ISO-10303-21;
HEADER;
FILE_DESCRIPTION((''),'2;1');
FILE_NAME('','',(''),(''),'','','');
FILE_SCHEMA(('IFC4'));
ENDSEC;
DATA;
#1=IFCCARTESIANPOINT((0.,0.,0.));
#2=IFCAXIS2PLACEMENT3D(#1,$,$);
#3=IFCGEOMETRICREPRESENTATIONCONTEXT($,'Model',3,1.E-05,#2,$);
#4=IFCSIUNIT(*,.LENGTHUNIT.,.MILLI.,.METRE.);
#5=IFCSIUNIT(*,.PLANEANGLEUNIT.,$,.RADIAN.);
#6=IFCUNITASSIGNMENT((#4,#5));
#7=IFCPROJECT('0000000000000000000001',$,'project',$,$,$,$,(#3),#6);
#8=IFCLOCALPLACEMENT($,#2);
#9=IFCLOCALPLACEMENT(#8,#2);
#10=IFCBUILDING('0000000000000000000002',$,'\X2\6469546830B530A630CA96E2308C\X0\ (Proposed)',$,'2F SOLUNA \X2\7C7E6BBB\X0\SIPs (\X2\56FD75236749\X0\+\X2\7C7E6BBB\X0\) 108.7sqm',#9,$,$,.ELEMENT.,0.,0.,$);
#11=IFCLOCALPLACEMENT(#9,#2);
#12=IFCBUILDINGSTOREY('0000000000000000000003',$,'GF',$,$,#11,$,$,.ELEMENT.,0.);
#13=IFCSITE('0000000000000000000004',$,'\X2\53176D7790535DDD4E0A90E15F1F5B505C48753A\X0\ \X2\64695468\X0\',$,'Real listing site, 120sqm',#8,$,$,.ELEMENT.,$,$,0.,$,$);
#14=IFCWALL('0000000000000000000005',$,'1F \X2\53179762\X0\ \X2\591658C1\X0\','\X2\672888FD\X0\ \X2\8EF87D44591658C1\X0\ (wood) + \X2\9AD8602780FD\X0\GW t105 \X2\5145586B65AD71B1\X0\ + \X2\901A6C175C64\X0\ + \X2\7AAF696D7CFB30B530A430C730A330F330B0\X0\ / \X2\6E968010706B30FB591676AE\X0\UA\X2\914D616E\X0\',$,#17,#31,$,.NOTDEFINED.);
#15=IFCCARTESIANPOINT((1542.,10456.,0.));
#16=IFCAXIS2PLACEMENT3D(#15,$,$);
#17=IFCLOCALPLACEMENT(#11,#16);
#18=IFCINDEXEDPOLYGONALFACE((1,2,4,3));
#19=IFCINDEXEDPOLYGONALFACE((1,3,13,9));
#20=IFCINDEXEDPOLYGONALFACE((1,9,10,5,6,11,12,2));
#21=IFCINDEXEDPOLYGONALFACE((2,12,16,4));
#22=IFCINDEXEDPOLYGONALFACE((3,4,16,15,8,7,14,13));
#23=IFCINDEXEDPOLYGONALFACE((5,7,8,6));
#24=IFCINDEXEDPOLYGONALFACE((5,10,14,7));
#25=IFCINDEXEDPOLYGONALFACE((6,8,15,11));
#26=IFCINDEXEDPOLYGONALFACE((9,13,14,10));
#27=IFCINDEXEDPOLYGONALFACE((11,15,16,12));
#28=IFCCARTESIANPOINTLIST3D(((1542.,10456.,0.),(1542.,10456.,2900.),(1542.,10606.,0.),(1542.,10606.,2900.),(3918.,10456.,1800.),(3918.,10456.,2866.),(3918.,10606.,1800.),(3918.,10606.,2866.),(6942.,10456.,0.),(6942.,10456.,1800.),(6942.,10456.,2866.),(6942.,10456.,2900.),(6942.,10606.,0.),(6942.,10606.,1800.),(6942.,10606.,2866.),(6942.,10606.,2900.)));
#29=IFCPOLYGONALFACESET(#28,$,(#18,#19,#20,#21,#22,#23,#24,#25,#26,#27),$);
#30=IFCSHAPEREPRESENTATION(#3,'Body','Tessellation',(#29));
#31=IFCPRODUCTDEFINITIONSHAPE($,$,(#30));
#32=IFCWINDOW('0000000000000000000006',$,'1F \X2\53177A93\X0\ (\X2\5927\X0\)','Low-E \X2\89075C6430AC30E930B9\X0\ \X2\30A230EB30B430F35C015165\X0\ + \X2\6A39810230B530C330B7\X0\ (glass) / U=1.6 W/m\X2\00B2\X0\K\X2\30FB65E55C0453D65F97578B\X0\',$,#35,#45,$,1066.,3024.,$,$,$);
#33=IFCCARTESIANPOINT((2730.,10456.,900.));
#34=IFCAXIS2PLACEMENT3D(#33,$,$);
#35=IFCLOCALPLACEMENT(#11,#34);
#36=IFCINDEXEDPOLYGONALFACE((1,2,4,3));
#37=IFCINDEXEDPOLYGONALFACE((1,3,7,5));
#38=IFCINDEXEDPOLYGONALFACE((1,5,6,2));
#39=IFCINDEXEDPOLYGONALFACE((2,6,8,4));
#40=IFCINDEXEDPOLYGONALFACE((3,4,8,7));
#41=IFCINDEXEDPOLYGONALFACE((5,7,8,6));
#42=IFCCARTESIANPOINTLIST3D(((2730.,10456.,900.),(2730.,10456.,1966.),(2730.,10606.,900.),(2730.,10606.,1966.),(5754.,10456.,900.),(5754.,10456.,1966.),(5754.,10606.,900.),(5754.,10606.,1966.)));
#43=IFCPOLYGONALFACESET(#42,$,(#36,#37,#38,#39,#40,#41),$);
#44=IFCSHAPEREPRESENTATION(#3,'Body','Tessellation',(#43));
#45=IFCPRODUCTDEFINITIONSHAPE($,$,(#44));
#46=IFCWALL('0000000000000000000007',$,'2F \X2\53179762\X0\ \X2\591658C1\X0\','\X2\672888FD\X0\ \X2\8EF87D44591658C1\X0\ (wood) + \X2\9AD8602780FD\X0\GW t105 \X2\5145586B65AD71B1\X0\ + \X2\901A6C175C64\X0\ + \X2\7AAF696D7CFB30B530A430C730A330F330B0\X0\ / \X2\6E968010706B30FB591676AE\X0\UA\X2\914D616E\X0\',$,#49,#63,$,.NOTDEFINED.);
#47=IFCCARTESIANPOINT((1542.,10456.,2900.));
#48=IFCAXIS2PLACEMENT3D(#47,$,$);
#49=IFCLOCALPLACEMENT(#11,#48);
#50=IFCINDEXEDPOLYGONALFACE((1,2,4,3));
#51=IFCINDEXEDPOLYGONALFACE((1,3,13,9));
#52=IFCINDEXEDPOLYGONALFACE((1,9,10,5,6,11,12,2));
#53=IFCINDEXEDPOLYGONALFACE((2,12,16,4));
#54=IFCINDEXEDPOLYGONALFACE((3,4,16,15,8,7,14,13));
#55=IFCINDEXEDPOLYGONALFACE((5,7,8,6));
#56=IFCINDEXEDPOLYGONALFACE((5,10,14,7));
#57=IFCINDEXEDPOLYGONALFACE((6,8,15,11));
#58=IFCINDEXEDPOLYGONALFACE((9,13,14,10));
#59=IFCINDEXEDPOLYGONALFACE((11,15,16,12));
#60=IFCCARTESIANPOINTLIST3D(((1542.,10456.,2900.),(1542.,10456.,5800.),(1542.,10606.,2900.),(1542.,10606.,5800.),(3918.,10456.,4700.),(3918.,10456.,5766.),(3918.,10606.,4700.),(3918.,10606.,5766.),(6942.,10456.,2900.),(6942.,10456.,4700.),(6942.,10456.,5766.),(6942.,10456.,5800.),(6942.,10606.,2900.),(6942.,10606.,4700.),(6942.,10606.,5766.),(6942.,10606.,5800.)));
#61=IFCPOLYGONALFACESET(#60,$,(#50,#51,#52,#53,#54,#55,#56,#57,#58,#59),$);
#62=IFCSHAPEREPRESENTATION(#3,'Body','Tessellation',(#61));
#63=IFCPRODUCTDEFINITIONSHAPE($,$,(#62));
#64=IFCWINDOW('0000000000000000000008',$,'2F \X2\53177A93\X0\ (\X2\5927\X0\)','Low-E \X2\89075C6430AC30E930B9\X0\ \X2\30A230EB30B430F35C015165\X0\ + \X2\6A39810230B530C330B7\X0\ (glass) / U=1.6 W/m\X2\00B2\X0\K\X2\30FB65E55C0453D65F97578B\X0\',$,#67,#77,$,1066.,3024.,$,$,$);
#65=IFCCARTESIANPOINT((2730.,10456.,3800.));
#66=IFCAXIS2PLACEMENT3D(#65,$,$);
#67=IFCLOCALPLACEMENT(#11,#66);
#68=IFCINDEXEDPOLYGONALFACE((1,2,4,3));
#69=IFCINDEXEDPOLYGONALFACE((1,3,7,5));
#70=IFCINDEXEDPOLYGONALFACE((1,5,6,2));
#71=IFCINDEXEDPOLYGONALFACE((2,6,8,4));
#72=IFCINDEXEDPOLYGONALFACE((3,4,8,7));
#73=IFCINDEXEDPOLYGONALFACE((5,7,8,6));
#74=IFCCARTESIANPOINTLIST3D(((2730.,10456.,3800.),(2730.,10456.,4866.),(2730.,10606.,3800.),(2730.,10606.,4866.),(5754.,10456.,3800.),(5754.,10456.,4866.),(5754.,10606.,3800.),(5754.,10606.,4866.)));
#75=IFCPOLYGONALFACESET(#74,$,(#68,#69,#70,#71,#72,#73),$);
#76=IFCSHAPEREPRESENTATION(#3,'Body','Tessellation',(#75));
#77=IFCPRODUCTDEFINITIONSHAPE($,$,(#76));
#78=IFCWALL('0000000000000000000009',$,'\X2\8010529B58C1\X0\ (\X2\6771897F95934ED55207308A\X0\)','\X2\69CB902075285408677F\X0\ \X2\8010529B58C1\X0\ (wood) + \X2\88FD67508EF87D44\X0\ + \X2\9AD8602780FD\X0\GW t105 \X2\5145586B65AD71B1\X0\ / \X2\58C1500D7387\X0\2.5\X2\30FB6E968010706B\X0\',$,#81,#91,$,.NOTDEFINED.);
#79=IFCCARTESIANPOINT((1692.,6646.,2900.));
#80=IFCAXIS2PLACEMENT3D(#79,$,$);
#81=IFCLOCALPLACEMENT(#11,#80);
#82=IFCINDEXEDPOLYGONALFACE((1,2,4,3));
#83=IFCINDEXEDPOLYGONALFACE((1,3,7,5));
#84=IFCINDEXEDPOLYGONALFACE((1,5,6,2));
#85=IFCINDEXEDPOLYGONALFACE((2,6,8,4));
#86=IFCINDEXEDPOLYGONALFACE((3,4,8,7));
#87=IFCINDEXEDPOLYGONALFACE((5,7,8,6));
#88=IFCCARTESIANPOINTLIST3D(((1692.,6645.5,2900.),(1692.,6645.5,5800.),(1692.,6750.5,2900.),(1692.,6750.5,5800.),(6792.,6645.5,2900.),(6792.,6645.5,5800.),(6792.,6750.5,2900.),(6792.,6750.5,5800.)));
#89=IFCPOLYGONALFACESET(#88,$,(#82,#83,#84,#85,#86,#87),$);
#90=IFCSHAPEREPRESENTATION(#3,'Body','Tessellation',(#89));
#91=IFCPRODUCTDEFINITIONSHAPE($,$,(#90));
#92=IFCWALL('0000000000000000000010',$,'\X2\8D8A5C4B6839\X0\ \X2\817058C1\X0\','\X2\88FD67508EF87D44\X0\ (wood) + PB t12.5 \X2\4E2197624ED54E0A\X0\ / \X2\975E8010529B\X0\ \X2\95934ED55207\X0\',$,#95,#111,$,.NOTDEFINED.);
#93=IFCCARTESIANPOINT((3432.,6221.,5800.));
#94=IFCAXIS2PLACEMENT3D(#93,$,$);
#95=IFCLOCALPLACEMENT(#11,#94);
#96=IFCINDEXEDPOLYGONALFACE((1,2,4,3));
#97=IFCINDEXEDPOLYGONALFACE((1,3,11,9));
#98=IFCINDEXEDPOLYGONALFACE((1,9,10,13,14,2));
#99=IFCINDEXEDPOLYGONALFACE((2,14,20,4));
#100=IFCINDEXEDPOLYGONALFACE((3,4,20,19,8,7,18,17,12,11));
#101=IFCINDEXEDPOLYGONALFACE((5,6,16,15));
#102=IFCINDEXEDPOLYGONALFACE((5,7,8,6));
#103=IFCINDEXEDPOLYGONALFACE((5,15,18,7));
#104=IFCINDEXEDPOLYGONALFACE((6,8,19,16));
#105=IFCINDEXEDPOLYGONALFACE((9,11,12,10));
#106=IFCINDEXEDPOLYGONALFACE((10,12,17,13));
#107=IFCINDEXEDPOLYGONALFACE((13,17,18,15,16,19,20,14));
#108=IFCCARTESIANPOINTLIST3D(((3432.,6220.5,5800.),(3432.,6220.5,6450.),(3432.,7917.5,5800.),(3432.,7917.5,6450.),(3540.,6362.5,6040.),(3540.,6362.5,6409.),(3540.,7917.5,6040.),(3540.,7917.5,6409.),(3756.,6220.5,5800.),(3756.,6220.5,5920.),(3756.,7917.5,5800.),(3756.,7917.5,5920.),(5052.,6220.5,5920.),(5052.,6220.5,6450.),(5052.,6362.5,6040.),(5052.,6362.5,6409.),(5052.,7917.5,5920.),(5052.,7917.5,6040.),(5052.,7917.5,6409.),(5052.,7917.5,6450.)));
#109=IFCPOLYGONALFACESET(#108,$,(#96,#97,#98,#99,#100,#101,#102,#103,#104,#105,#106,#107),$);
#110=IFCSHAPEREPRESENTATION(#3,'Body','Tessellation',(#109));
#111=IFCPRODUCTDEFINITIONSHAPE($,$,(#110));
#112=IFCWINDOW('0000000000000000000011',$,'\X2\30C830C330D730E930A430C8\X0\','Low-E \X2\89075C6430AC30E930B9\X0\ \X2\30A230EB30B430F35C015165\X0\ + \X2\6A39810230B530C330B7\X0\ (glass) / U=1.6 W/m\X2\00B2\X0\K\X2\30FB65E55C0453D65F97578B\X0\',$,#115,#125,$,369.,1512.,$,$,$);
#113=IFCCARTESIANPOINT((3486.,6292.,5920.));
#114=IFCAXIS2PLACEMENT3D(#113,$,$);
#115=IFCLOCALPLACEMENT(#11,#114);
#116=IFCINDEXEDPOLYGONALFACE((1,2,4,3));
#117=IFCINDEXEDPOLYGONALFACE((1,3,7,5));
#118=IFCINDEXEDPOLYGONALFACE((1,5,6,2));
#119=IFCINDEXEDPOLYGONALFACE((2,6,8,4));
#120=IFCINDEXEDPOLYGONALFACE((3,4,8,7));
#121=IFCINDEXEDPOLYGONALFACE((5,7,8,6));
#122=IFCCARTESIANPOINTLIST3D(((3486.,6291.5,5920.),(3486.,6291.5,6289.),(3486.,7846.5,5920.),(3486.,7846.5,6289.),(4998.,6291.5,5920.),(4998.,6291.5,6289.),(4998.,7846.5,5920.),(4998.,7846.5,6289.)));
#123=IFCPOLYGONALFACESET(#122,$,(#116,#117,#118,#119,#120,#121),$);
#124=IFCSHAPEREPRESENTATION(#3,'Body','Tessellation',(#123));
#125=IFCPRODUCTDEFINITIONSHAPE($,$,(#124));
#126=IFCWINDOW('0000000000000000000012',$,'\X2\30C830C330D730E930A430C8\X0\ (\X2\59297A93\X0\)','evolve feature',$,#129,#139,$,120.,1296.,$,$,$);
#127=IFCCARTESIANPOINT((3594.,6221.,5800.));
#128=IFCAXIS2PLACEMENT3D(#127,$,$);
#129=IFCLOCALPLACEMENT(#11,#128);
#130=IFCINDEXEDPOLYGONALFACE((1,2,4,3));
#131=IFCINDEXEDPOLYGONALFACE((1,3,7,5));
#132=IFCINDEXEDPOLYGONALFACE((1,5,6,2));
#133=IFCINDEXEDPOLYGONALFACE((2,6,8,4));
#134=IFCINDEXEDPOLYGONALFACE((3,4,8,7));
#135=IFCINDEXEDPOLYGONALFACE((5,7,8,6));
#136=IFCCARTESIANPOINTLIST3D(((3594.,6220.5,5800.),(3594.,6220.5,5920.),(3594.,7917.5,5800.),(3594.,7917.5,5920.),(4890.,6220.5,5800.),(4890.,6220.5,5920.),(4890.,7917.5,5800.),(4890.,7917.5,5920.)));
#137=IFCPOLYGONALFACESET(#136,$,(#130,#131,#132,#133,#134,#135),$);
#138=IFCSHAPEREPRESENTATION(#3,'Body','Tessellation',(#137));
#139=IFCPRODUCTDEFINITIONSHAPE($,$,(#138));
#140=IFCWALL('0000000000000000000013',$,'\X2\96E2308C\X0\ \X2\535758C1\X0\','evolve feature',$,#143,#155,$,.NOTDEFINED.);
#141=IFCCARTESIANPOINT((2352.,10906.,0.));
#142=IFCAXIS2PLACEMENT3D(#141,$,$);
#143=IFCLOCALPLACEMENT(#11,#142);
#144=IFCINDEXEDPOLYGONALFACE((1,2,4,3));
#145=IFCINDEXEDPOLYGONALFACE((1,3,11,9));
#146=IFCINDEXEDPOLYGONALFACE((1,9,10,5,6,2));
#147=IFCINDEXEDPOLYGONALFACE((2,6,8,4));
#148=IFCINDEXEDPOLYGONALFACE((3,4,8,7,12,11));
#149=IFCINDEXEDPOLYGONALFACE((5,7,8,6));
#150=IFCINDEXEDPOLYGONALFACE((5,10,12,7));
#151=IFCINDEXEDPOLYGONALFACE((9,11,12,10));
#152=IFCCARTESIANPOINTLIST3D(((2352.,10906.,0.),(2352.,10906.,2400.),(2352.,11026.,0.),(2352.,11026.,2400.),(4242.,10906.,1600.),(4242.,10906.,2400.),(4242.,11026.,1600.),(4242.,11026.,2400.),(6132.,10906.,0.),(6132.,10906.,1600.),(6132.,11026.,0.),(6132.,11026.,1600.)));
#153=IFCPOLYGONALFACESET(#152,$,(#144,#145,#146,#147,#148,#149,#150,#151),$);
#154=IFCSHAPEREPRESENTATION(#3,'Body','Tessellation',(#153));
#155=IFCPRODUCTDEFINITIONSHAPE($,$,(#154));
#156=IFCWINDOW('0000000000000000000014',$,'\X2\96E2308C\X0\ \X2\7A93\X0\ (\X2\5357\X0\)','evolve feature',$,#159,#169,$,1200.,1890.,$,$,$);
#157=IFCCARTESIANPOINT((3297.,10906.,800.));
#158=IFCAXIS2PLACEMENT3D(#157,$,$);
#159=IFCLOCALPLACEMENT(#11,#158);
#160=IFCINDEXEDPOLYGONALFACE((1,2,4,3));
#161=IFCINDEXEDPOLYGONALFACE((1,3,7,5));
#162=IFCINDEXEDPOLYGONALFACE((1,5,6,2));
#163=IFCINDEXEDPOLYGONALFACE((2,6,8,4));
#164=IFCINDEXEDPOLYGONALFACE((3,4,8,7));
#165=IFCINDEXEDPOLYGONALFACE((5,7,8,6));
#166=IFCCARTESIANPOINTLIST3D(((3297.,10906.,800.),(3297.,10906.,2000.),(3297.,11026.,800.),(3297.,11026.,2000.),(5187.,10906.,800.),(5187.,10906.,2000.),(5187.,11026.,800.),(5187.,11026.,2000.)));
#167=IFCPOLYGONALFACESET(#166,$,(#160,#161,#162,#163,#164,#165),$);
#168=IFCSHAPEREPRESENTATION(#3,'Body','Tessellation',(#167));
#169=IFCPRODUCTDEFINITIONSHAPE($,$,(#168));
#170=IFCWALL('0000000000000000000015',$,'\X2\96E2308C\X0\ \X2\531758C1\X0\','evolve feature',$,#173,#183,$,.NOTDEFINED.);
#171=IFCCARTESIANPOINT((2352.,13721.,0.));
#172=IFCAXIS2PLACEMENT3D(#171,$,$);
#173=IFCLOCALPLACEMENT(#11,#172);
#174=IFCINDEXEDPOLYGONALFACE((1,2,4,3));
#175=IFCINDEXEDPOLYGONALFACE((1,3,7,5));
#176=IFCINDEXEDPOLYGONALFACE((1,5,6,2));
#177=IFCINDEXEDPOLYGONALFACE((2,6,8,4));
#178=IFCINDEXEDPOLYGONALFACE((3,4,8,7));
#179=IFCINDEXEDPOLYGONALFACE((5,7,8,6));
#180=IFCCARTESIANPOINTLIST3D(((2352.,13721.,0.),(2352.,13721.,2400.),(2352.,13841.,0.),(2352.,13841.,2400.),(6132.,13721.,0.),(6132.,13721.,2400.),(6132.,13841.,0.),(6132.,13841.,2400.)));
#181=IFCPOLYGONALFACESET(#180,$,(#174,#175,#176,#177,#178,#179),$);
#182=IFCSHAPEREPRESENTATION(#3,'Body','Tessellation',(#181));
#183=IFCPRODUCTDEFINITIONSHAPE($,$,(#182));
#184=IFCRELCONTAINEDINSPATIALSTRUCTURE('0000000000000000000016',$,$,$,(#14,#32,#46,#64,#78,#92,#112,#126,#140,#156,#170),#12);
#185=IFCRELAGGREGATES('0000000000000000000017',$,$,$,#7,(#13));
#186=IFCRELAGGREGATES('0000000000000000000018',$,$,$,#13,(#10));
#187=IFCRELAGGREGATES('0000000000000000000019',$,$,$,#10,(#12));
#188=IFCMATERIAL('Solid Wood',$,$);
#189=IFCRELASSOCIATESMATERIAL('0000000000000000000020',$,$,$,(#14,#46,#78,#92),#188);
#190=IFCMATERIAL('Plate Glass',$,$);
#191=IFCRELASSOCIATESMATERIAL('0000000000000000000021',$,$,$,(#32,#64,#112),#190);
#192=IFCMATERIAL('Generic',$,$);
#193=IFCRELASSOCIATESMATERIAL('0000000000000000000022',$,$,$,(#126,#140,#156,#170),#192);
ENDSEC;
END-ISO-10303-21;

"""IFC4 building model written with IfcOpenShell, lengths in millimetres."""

from ifc_helpers import new_model, si_unit, frame, frame_2d, origin, place, context, project, spatial, rectangle, extrude, material, element, fill, save


model = new_model("IFC4")

# Units and contexts
model_context = context("Model", 3, precision=1e-05, world=origin())
ifc_project = project(units=[si_unit("LENGTHUNIT", "METRE", prefix="MILLI"), si_unit("PLANEANGLEUNIT", "RADIAN")], contexts=[model_context])

# Site, building, storey
site_placement = place(None, origin())
site = spatial("IfcSite", under=ifc_project, at=site_placement, Name="北海道川上郡弟子屈町 摩周", ObjectType="Real listing site, 120sqm", CompositionType="ELEMENT", RefElevation=0.0)
building_placement = place(site_placement, origin())
building = spatial("IfcBuilding", under=site, at=building_placement, Name="摩周サウナ離れ (Proposed)", ObjectType="2F SOLUNA 籾殻SIPs (国産杉+籾殻) 108.7sqm", CompositionType="ELEMENT", ElevationOfRefHeight=0.0, ElevationOfTerrain=0.0)
storey_placement = place(building_placement, origin())
storey = spatial("IfcBuildingStorey", under=building, at=storey_placement, Name="GF", CompositionType="ELEMENT", Elevation=0.0)

# Shared definitions
ifc_material_1 = material(Name="Generic")

# Wall, opening, window
ifc_material_2 = material(Name="Solid Wood")
wall_1_placement = place(storey_placement, frame((1542.0, 10456.0, 0.0)))
wall_1 = element("IfcWall", 1, at=wall_1_placement, inside=storey, material=ifc_material_2, Name="1F 北面 外壁", Description="木製 軸組外壁 (wood) + 高性能GW t105 充填断熱 + 通気層 + 窯業系サイディング / 準耐火・外皮UA配慮", PredefinedType="NOTDEFINED", context=model_context, shape_type="SweptSolid", body=[
    extrude(rectangle(XDim=5400.0, YDim=150.0, at=frame_2d((2700.0, 75.0))), frame((1542.0, 10456.0, 0.0)), (0.0, 0.0, 1.0), 2900.0),
])
opening_1_placement = place(storey_placement, frame((2730.0, 10456.0, 900.0)))
opening_1 = element("IfcOpeningElement", 2, at=opening_1_placement, cuts=wall_1, PredefinedType="NOTDEFINED", context=model_context, shape_type="SweptSolid", body=[
    extrude(rectangle(XDim=3024.0, YDim=150.0, at=frame_2d((1512.0, 75.0))), frame((2730.0, 10456.0, 900.0)), (0.0, 0.0, 1.0), 1066.0),
])
ifc_material_3 = material(Name="Plate Glass")
window_1_placement = place(storey_placement, frame((2730.0, 10456.0, 900.0)))
window_1 = element("IfcWindow", 3, at=window_1_placement, inside=storey, material=ifc_material_3, Name="1F 北窓 (大)", Description="Low-E 複層ガラス アルゴン封入 + 樹脂サッシ (glass) / U=1.6 W/m²K・日射取得型", OverallHeight=1066.0, OverallWidth=3024.0, context=model_context, shape_type="SweptSolid", body=[
    extrude(rectangle(XDim=3024.0, YDim=150.0, at=frame_2d((1512.0, 75.0))), frame((2730.0, 10456.0, 900.0)), (0.0, 0.0, 1.0), 1066.0),
])
fill(opening_1, window_1)

# Wall, opening, window
wall_2_placement = place(storey_placement, frame((1542.0, 10456.0, 2900.0)))
wall_2 = element("IfcWall", 4, at=wall_2_placement, inside=storey, material=ifc_material_2, Name="2F 北面 外壁", Description="木製 軸組外壁 (wood) + 高性能GW t105 充填断熱 + 通気層 + 窯業系サイディング / 準耐火・外皮UA配慮", PredefinedType="NOTDEFINED", context=model_context, shape_type="SweptSolid", body=[
    extrude(rectangle(XDim=5400.0, YDim=150.0, at=frame_2d((2700.0, 75.0))), frame((1542.0, 10456.0, 2900.0)), (0.0, 0.0, 1.0), 2900.0),
])
opening_2_placement = place(storey_placement, frame((2730.0, 10456.0, 3800.0)))
opening_2 = element("IfcOpeningElement", 5, at=opening_2_placement, cuts=wall_2, PredefinedType="NOTDEFINED", context=model_context, shape_type="SweptSolid", body=[
    extrude(rectangle(XDim=3024.0, YDim=150.0, at=frame_2d((1512.0, 75.0))), frame((2730.0, 10456.0, 3800.0)), (0.0, 0.0, 1.0), 1066.0),
])
window_2_placement = place(storey_placement, frame((2730.0, 10456.0, 3800.0)))
window_2 = element("IfcWindow", 6, at=window_2_placement, inside=storey, material=ifc_material_3, Name="2F 北窓 (大)", Description="Low-E 複層ガラス アルゴン封入 + 樹脂サッシ (glass) / U=1.6 W/m²K・日射取得型", OverallHeight=1066.0, OverallWidth=3024.0, context=model_context, shape_type="SweptSolid", body=[
    extrude(rectangle(XDim=3024.0, YDim=150.0, at=frame_2d((1512.0, 75.0))), frame((2730.0, 10456.0, 3800.0)), (0.0, 0.0, 1.0), 1066.0),
])
fill(opening_2, window_2)

# Wall
wall_3_placement = place(storey_placement, frame((1692.0, 6646.0, 2900.0)))
element("IfcWall", 7, at=wall_3_placement, inside=storey, material=ifc_material_2, Name="耐力壁 (東西間仕切り)", Description="構造用合板 耐力壁 (wood) + 製材軸組 + 高性能GW t105 充填断熱 / 壁倍率2.5・準耐火", PredefinedType="NOTDEFINED", context=model_context, shape_type="SweptSolid", body=[
    extrude(rectangle(XDim=5100.0, YDim=105.0, at=frame_2d((2550.0, 52.0))), frame((1692.0, 6646.0, 2900.0)), (0.0, 0.0, 1.0), 2900.0),
])

# Wall, openings, windows
wall_4_placement = place(storey_placement, frame((3432.0, 6221.0, 5800.0)))
wall_4 = element("IfcWall", 8, at=wall_4_placement, inside=storey, material=ifc_material_2, Name="越屋根 腰壁", Description="製材軸組 (wood) + PB t12.5 両面仕上 / 非耐力 間仕切", PredefinedType="NOTDEFINED", context=model_context, shape_type="SweptSolid", body=[
    extrude(rectangle(XDim=1620.0, YDim=1697.0, at=frame_2d((810.0, 848.0))), frame((3432.0, 6221.0, 5800.0)), (0.0, 0.0, 1.0), 650.0),
])
opening_3_placement = place(storey_placement, frame((3486.0, 6292.0, 5920.0)))
opening_3 = element("IfcOpeningElement", 9, at=opening_3_placement, cuts=wall_4, PredefinedType="NOTDEFINED", context=model_context, shape_type="SweptSolid", body=[
    extrude(rectangle(XDim=1512.0, YDim=1555.0, at=frame_2d((756.0, 777.0))), frame((3486.0, 6292.0, 5920.0)), (0.0, 0.0, 1.0), 369.0),
])
opening_4_placement = place(storey_placement, frame((3594.0, 6221.0, 5800.0)))
opening_4 = element("IfcOpeningElement", 10, at=opening_4_placement, cuts=wall_4, PredefinedType="NOTDEFINED", context=model_context, shape_type="SweptSolid", body=[
    extrude(rectangle(XDim=1296.0, YDim=1697.0, at=frame_2d((648.0, 848.0))), frame((3594.0, 6221.0, 5800.0)), (0.0, 0.0, 1.0), 120.0),
])
window_3_placement = place(storey_placement, frame((3486.0, 6292.0, 5920.0)))
window_3 = element("IfcWindow", 11, at=window_3_placement, inside=storey, material=ifc_material_3, Name="トップライト", Description="Low-E 複層ガラス アルゴン封入 + 樹脂サッシ (glass) / U=1.6 W/m²K・日射取得型", OverallHeight=369.0, OverallWidth=1512.0, context=model_context, shape_type="SweptSolid", body=[
    extrude(rectangle(XDim=1512.0, YDim=1555.0, at=frame_2d((756.0, 777.0))), frame((3486.0, 6292.0, 5920.0)), (0.0, 0.0, 1.0), 369.0),
])
fill(opening_3, window_3)
window_4_placement = place(storey_placement, frame((3594.0, 6221.0, 5800.0)))
window_4 = element("IfcWindow", 12, at=window_4_placement, inside=storey, material=ifc_material_1, Name="トップライト (天窓)", Description="evolve feature", OverallHeight=120.0, OverallWidth=1296.0, context=model_context, shape_type="SweptSolid", body=[
    extrude(rectangle(XDim=1296.0, YDim=1697.0, at=frame_2d((648.0, 848.0))), frame((3594.0, 6221.0, 5800.0)), (0.0, 0.0, 1.0), 120.0),
])
fill(opening_4, window_4)

# Wall, opening, window
wall_5_placement = place(storey_placement, frame((2352.0, 10906.0, 0.0)))
wall_5 = element("IfcWall", 13, at=wall_5_placement, inside=storey, material=ifc_material_1, Name="離れ 南壁", Description="evolve feature", PredefinedType="NOTDEFINED", context=model_context, shape_type="SweptSolid", body=[
    extrude(rectangle(XDim=3780.0, YDim=120.0, at=frame_2d((1890.0, 60.0))), frame((2352.0, 10906.0, 0.0)), (0.0, 0.0, 1.0), 2400.0),
])
opening_5_placement = place(storey_placement, frame((3297.0, 10906.0, 800.0)))
opening_5 = element("IfcOpeningElement", 14, at=opening_5_placement, cuts=wall_5, PredefinedType="NOTDEFINED", context=model_context, shape_type="SweptSolid", body=[
    extrude(rectangle(XDim=1890.0, YDim=120.0, at=frame_2d((945.0, 60.0))), frame((3297.0, 10906.0, 800.0)), (0.0, 0.0, 1.0), 1200.0),
])
window_5_placement = place(storey_placement, frame((3297.0, 10906.0, 800.0)))
window_5 = element("IfcWindow", 15, at=window_5_placement, inside=storey, material=ifc_material_1, Name="離れ 窓 (南)", Description="evolve feature", OverallHeight=1200.0, OverallWidth=1890.0, context=model_context, shape_type="SweptSolid", body=[
    extrude(rectangle(XDim=1890.0, YDim=120.0, at=frame_2d((945.0, 60.0))), frame((3297.0, 10906.0, 800.0)), (0.0, 0.0, 1.0), 1200.0),
])
fill(opening_5, window_5)

# Wall
wall_6_placement = place(storey_placement, frame((2352.0, 13721.0, 0.0)))
element("IfcWall", 16, at=wall_6_placement, inside=storey, material=ifc_material_1, Name="離れ 北壁", Description="evolve feature", PredefinedType="NOTDEFINED", context=model_context, shape_type="SweptSolid", body=[
    extrude(rectangle(XDim=3780.0, YDim=120.0, at=frame_2d((1890.0, 60.0))), frame((2352.0, 13721.0, 0.0)), (0.0, 0.0, 1.0), 2400.0),
])

save(model, "model.ifc")
